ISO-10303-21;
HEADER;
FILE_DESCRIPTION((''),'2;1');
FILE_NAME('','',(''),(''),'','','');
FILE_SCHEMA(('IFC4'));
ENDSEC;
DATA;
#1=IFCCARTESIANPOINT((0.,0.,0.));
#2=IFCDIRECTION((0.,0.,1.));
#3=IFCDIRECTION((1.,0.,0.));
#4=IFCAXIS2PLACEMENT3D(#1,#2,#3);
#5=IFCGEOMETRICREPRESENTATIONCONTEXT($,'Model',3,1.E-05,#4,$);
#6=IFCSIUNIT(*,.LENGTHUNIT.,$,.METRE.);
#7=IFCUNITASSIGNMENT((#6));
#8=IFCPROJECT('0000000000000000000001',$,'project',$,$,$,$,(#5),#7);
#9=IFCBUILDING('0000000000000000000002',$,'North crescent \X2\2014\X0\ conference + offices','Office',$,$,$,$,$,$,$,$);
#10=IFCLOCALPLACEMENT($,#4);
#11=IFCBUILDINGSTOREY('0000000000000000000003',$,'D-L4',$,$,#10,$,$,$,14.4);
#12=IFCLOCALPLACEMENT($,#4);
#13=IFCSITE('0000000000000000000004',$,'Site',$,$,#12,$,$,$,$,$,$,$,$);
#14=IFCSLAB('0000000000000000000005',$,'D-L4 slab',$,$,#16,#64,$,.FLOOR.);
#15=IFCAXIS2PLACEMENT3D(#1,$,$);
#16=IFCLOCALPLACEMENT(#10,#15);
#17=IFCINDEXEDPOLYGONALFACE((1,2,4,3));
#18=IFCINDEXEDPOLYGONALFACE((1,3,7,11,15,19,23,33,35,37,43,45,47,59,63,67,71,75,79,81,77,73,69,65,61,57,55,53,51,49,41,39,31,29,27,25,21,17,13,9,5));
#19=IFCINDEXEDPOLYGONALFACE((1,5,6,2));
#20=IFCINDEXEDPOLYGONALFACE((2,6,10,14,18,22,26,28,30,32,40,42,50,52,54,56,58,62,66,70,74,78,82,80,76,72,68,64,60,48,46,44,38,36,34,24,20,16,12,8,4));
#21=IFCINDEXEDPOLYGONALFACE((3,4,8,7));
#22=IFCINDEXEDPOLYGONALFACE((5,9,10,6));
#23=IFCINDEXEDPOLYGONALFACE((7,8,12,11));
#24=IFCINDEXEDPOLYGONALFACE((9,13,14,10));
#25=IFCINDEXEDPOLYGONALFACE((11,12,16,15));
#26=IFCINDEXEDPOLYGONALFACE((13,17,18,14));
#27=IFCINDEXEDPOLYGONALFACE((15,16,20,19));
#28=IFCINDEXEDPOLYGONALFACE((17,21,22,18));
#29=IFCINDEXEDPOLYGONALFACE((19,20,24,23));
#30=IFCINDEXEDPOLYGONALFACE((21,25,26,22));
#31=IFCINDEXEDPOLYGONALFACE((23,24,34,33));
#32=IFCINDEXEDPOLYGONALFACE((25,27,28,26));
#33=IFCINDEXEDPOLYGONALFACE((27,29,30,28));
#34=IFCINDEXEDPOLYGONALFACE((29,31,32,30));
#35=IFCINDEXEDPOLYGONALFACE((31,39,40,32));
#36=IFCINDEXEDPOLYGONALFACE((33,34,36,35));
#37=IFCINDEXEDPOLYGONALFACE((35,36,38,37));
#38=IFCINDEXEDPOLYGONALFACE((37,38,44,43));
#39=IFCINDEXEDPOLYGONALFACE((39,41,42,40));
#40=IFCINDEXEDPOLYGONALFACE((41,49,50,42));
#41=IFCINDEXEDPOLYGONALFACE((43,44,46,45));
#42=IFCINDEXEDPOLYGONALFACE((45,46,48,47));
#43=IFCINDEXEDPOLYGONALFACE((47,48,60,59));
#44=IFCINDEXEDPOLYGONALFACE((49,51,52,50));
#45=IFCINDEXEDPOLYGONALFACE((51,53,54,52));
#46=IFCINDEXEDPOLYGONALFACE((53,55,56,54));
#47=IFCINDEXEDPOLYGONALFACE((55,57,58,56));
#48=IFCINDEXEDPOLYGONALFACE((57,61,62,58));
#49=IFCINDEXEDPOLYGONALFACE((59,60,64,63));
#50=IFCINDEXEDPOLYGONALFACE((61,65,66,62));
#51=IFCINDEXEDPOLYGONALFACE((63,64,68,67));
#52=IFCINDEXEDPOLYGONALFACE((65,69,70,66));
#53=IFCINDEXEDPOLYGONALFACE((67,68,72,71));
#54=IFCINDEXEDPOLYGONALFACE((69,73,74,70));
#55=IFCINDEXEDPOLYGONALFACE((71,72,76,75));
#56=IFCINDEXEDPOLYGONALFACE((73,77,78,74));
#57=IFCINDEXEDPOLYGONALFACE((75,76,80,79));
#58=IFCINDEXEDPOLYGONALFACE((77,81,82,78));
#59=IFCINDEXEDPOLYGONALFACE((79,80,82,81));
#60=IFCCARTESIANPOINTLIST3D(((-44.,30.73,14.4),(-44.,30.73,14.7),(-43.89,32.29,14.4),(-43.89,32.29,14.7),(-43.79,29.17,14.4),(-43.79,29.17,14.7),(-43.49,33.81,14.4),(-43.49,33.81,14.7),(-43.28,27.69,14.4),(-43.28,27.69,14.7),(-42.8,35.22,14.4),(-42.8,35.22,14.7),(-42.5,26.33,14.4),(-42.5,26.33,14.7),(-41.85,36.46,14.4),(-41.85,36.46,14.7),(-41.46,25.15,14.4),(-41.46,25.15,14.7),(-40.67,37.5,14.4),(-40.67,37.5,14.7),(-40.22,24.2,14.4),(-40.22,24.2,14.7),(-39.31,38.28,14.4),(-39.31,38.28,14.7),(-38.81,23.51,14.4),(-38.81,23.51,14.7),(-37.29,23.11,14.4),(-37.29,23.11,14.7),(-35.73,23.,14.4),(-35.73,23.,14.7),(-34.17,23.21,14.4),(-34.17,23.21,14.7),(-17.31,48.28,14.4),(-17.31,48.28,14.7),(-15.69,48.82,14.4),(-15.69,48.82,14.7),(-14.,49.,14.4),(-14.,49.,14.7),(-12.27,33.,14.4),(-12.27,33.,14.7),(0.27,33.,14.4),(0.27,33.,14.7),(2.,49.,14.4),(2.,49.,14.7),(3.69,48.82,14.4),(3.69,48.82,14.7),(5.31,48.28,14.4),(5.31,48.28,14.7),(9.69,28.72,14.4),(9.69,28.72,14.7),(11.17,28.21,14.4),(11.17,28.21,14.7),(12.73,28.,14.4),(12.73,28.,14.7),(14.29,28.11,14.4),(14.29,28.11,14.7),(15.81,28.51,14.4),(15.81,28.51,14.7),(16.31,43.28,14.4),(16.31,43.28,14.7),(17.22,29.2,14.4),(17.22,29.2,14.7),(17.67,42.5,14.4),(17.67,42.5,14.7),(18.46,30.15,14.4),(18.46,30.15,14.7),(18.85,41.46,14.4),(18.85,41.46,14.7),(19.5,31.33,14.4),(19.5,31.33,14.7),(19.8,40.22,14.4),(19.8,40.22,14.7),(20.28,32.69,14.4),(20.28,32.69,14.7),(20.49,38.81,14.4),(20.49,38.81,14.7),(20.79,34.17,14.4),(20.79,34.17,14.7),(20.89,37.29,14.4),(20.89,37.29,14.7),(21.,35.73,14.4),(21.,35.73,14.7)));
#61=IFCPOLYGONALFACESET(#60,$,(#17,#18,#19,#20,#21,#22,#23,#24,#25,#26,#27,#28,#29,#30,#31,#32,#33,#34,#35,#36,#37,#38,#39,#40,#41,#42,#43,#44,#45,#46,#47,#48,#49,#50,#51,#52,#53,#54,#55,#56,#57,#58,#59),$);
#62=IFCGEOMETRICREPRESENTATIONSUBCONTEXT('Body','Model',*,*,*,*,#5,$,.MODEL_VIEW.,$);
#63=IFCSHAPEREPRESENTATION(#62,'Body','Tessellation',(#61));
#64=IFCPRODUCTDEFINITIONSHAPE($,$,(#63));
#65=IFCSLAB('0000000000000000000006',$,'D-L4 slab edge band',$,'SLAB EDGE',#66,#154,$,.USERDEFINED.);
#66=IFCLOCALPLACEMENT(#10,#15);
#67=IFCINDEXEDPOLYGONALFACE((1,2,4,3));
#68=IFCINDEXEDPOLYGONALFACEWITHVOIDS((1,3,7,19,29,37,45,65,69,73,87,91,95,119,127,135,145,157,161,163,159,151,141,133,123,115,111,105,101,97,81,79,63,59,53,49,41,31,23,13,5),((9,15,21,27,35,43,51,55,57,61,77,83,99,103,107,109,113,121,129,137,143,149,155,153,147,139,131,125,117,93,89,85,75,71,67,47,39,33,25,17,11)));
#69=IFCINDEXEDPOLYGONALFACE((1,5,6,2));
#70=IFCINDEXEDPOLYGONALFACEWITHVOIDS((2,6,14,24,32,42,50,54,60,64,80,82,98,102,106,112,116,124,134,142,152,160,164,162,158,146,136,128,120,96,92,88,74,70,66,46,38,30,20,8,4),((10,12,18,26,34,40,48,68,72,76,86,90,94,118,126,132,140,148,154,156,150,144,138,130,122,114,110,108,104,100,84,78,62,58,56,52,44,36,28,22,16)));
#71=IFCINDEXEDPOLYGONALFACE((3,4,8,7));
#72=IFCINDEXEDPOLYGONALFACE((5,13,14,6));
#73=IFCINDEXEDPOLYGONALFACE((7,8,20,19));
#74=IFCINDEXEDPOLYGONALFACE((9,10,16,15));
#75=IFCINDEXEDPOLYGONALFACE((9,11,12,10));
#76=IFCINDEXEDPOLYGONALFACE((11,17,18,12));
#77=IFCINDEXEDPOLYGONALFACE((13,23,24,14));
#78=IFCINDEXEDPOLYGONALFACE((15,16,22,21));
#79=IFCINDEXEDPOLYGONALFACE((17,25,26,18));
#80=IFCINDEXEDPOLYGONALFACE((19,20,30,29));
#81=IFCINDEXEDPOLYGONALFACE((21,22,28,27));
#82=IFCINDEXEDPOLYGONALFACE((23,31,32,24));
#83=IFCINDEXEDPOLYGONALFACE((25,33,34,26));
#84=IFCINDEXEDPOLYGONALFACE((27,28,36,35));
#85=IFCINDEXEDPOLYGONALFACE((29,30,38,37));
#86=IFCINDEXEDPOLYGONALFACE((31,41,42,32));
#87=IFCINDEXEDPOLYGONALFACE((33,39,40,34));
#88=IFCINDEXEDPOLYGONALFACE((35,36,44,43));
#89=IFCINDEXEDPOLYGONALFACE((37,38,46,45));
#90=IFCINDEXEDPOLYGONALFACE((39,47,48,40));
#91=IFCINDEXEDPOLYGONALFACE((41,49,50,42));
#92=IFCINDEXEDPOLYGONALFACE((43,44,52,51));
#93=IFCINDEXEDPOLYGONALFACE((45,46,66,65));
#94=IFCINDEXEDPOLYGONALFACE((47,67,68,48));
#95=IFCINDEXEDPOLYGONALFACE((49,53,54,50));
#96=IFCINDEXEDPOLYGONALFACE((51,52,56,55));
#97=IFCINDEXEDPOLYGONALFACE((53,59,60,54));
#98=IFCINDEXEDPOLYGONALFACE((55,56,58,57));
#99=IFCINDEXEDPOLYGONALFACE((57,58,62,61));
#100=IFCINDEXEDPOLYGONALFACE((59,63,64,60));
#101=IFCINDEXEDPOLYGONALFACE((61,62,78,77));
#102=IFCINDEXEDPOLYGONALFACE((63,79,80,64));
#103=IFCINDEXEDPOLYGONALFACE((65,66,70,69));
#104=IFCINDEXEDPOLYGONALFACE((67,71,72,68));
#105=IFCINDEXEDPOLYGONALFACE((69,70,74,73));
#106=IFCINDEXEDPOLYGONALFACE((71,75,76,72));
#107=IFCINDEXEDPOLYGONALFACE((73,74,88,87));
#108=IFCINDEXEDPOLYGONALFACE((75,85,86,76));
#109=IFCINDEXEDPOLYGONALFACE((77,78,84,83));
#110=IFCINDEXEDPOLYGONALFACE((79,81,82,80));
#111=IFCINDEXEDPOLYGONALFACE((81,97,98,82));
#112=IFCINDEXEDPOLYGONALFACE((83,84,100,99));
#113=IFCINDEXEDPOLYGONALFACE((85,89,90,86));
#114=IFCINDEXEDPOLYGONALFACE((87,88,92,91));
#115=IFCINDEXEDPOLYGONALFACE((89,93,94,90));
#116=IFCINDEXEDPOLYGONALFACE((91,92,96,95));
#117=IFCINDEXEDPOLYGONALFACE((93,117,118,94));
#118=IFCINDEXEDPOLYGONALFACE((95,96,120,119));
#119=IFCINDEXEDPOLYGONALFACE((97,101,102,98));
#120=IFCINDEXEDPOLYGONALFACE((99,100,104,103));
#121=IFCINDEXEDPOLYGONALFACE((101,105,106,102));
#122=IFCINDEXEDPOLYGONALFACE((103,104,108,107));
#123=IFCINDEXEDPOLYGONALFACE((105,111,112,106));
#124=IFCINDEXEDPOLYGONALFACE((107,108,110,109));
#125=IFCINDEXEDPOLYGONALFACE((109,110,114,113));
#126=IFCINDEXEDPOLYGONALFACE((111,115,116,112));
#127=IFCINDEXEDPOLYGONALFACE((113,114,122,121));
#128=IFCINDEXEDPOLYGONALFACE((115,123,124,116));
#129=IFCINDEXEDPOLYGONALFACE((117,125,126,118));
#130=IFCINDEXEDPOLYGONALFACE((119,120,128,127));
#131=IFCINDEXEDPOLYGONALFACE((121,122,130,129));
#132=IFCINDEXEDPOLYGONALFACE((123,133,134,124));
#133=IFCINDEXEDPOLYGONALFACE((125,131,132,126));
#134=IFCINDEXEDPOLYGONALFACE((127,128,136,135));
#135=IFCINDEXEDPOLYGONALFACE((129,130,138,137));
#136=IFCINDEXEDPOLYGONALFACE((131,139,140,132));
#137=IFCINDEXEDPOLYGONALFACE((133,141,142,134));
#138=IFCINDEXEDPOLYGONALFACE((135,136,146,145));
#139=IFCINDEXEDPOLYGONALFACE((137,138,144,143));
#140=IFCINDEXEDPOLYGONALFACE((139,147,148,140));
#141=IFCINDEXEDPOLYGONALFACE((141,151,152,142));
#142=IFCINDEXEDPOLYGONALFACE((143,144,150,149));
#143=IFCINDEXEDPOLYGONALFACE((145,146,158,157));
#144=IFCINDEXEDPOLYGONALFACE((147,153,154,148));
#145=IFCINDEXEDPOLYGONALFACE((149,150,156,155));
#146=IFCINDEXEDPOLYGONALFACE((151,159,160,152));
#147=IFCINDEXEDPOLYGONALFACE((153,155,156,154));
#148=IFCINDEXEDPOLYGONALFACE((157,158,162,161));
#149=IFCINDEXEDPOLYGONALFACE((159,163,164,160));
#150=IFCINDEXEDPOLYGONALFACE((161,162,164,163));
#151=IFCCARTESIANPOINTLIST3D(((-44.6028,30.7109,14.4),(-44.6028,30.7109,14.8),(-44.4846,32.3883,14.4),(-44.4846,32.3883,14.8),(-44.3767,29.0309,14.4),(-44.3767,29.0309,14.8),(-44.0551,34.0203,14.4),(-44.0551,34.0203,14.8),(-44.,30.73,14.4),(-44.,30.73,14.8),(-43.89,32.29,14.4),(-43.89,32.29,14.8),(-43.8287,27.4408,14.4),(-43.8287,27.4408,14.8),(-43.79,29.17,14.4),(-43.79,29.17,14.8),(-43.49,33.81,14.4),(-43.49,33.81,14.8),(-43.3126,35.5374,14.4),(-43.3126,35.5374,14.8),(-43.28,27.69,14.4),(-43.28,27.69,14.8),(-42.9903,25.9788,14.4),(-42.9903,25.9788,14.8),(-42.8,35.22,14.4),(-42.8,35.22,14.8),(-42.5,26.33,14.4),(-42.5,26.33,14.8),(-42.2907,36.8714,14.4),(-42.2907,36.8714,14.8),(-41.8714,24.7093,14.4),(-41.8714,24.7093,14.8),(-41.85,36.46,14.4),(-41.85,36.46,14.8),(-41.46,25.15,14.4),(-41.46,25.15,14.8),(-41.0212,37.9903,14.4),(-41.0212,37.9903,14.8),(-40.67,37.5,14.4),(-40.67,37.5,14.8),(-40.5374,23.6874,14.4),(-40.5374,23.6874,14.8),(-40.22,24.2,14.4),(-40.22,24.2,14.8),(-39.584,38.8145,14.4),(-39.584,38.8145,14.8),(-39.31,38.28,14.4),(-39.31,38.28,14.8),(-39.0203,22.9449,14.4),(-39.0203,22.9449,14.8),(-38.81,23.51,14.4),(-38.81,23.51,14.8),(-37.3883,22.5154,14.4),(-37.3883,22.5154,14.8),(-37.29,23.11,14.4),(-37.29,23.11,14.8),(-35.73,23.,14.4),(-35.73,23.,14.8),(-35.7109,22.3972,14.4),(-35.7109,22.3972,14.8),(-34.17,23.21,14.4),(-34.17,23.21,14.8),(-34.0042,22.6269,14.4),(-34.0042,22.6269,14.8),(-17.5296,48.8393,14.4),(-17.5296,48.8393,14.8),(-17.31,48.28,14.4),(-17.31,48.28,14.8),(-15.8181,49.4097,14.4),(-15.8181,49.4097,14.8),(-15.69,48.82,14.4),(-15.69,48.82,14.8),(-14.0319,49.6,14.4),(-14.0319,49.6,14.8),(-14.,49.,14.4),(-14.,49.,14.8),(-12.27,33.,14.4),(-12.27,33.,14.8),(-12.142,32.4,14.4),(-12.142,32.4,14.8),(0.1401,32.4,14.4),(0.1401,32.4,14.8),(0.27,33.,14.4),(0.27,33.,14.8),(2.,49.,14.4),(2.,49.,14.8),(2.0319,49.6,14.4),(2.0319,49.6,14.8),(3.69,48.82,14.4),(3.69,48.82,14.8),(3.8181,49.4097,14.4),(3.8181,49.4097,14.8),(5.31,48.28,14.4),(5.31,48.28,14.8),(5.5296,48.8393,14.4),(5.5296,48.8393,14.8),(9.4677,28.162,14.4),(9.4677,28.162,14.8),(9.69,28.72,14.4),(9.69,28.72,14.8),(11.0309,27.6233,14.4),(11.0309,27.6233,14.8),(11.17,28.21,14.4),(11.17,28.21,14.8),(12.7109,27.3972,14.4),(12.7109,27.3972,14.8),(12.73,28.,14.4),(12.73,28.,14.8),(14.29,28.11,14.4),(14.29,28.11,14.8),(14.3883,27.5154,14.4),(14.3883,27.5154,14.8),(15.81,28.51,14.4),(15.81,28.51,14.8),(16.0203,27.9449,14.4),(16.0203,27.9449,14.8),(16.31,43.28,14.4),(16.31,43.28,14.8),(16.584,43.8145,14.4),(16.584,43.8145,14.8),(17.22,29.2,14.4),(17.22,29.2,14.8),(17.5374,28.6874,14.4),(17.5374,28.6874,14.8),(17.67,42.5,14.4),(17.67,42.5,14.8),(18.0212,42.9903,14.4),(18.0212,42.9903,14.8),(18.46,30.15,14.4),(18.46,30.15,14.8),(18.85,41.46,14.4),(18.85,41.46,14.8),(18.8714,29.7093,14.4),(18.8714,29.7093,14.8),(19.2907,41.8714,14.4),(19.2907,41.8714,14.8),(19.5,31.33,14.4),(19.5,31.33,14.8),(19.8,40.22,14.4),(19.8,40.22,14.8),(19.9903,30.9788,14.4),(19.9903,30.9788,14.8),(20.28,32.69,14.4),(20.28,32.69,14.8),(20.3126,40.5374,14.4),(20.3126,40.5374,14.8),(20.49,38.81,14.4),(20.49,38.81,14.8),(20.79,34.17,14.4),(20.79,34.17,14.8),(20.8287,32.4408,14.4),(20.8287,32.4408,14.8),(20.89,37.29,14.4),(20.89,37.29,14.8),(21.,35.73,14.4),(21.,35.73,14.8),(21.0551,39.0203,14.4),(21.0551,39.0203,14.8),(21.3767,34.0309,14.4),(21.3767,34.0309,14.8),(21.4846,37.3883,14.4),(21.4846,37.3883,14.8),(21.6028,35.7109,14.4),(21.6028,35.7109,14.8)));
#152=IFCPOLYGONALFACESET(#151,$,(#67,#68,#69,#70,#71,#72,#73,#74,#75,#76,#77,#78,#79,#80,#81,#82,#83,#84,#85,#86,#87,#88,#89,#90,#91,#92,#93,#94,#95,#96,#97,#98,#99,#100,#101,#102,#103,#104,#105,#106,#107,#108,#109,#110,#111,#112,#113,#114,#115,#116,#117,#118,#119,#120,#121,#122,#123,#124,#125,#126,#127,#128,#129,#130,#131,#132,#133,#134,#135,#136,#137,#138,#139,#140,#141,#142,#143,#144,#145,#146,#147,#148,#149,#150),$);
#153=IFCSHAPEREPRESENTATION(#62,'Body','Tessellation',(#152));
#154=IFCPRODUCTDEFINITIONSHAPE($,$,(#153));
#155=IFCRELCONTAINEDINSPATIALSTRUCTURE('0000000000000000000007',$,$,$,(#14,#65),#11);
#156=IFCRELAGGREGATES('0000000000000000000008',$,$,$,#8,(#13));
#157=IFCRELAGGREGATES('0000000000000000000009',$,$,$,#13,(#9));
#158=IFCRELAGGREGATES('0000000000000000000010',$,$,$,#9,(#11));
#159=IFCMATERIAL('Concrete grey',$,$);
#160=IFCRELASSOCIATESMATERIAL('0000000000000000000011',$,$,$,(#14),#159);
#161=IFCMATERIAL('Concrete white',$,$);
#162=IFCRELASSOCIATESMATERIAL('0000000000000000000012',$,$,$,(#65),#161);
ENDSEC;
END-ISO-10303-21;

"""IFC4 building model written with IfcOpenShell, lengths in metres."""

from ifc_helpers import new_model, si_unit, frame, origin_with_axes, place, context, subcontext, project, spatial, polyline, outline, extrude, material, element, save


model = new_model("IFC4")

# Units and contexts
model_context = context("Model", 3, precision=1e-05, world=origin_with_axes())
body_context = subcontext(model_context, "Body", "Model", "MODEL_VIEW")
ifc_project = project(units=[si_unit("LENGTHUNIT", "METRE")], contexts=[model_context])

# Site, building, storey
site_placement = place(None, origin_with_axes())
site = spatial("IfcSite", under=ifc_project, at=site_placement, Name="Site")
building = spatial("IfcBuilding", under=site, Name="North crescent — conference + offices", Description="Office")
storey_placement = place(None, origin_with_axes())
storey = spatial("IfcBuildingStorey", under=building, at=storey_placement, Name="D-L4", Elevation=14.4)

# Slab
ifc_material_1 = material(Name="Concrete grey")
slab_1_placement = place(storey_placement, origin_with_axes())
element("IfcSlab", 1, at=slab_1_placement, inside=storey, material=ifc_material_1, Name="D-L4 slab", PredefinedType="FLOOR", context=body_context, shape_type="SweptSolid", body=[
    extrude(outline(polyline([(-17.31, 48.28), (-39.31, 38.28), (-40.67, 37.5), (-41.85, 36.46), (-42.8, 35.22), (-43.49, 33.81), (-43.89, 32.29), (-44.0, 30.73), (-43.79, 29.17), (-43.28, 27.69), (-42.5, 26.33), (-41.46, 25.15), (-40.22, 24.2), (-38.81, 23.51), (-37.29, 23.11), (-35.73, 23.0), (-34.17, 23.21), (-12.27, 33.0), (0.27, 33.0), (9.69, 28.72), (11.17, 28.21), (12.73, 28.0), (14.29, 28.11), (15.81, 28.51), (17.22, 29.2), (18.46, 30.15), (19.5, 31.33), (20.28, 32.69), (20.79, 34.17), (21.0, 35.73), (20.89, 37.29), (20.49, 38.81), (19.8, 40.22), (18.85, 41.46), (17.67, 42.5), (16.31, 43.28), (5.31, 48.28), (3.69, 48.82), (2.0, 49.0), (-14.0, 49.0), (-15.69, 48.82), (-17.31, 48.28)])), frame((0.0, 0.0, 14.4), z_axis=(0.0, 0.0, 1.0), x_axis=(1.0, 0.0, 0.0)), (0.0, 0.0, 1.0), 0.3),
])

# Slab
ifc_material_2 = material(Name="Concrete white")
slab_2_placement = place(storey_placement, origin_with_axes())
element("IfcSlab", 2, at=slab_2_placement, inside=storey, material=ifc_material_2, Name="D-L4 slab edge band", ObjectType="SLAB EDGE", PredefinedType="USERDEFINED", context=body_context, shape_type="SweptSolid", body=[
    extrude(outline(polyline([(-17.5296, 48.8393), (-39.584, 38.8145), (-41.0212, 37.9903), (-42.2907, 36.8714), (-43.3126, 35.5374), (-44.0551, 34.0203), (-44.4846, 32.3883), (-44.6028, 30.7109), (-44.3767, 29.0309), (-43.8287, 27.4408), (-42.9903, 25.9788), (-41.8714, 24.7093), (-40.5374, 23.6874), (-39.0203, 22.9449), (-37.3883, 22.5154), (-35.7109, 22.3972), (-34.0042, 22.6269), (-12.142, 32.4), (0.1401, 32.4), (9.4677, 28.162), (11.0309, 27.6233), (12.7109, 27.3972), (14.3883, 27.5154), (16.0203, 27.9449), (17.5374, 28.6874), (18.8714, 29.7093), (19.9903, 30.9788), (20.8287, 32.4408), (21.3767, 34.0309), (21.6028, 35.7109), (21.4846, 37.3883), (21.0551, 39.0203), (20.3126, 40.5374), (19.2907, 41.8714), (18.0212, 42.9903), (16.584, 43.8145), (5.5296, 48.8393), (3.8181, 49.4097), (2.0319, 49.6), (-14.0319, 49.6), (-15.8181, 49.4097), (-17.5296, 48.8393)]), holes=[polyline([(-17.31, 48.28), (-39.31, 38.28), (-40.67, 37.5), (-41.85, 36.46), (-42.8, 35.22), (-43.49, 33.81), (-43.89, 32.29), (-44.0, 30.73), (-43.79, 29.17), (-43.28, 27.69), (-42.5, 26.33), (-41.46, 25.15), (-40.22, 24.2), (-38.81, 23.51), (-37.29, 23.11), (-35.73, 23.0), (-34.17, 23.21), (-12.27, 33.0), (0.27, 33.0), (9.69, 28.72), (11.17, 28.21), (12.73, 28.0), (14.29, 28.11), (15.81, 28.51), (17.22, 29.2), (18.46, 30.15), (19.5, 31.33), (20.28, 32.69), (20.79, 34.17), (21.0, 35.73), (20.89, 37.29), (20.49, 38.81), (19.8, 40.22), (18.85, 41.46), (17.67, 42.5), (16.31, 43.28), (5.31, 48.28), (3.69, 48.82), (2.0, 49.0), (-14.0, 49.0), (-15.69, 48.82), (-17.31, 48.28)])]), frame((0.0, 0.0, 14.4), z_axis=(0.0, 0.0, 1.0), x_axis=(1.0, 0.0, 0.0)), (0.0, 0.0, 1.0), 0.4),
])

save(model, "model.ifc")
